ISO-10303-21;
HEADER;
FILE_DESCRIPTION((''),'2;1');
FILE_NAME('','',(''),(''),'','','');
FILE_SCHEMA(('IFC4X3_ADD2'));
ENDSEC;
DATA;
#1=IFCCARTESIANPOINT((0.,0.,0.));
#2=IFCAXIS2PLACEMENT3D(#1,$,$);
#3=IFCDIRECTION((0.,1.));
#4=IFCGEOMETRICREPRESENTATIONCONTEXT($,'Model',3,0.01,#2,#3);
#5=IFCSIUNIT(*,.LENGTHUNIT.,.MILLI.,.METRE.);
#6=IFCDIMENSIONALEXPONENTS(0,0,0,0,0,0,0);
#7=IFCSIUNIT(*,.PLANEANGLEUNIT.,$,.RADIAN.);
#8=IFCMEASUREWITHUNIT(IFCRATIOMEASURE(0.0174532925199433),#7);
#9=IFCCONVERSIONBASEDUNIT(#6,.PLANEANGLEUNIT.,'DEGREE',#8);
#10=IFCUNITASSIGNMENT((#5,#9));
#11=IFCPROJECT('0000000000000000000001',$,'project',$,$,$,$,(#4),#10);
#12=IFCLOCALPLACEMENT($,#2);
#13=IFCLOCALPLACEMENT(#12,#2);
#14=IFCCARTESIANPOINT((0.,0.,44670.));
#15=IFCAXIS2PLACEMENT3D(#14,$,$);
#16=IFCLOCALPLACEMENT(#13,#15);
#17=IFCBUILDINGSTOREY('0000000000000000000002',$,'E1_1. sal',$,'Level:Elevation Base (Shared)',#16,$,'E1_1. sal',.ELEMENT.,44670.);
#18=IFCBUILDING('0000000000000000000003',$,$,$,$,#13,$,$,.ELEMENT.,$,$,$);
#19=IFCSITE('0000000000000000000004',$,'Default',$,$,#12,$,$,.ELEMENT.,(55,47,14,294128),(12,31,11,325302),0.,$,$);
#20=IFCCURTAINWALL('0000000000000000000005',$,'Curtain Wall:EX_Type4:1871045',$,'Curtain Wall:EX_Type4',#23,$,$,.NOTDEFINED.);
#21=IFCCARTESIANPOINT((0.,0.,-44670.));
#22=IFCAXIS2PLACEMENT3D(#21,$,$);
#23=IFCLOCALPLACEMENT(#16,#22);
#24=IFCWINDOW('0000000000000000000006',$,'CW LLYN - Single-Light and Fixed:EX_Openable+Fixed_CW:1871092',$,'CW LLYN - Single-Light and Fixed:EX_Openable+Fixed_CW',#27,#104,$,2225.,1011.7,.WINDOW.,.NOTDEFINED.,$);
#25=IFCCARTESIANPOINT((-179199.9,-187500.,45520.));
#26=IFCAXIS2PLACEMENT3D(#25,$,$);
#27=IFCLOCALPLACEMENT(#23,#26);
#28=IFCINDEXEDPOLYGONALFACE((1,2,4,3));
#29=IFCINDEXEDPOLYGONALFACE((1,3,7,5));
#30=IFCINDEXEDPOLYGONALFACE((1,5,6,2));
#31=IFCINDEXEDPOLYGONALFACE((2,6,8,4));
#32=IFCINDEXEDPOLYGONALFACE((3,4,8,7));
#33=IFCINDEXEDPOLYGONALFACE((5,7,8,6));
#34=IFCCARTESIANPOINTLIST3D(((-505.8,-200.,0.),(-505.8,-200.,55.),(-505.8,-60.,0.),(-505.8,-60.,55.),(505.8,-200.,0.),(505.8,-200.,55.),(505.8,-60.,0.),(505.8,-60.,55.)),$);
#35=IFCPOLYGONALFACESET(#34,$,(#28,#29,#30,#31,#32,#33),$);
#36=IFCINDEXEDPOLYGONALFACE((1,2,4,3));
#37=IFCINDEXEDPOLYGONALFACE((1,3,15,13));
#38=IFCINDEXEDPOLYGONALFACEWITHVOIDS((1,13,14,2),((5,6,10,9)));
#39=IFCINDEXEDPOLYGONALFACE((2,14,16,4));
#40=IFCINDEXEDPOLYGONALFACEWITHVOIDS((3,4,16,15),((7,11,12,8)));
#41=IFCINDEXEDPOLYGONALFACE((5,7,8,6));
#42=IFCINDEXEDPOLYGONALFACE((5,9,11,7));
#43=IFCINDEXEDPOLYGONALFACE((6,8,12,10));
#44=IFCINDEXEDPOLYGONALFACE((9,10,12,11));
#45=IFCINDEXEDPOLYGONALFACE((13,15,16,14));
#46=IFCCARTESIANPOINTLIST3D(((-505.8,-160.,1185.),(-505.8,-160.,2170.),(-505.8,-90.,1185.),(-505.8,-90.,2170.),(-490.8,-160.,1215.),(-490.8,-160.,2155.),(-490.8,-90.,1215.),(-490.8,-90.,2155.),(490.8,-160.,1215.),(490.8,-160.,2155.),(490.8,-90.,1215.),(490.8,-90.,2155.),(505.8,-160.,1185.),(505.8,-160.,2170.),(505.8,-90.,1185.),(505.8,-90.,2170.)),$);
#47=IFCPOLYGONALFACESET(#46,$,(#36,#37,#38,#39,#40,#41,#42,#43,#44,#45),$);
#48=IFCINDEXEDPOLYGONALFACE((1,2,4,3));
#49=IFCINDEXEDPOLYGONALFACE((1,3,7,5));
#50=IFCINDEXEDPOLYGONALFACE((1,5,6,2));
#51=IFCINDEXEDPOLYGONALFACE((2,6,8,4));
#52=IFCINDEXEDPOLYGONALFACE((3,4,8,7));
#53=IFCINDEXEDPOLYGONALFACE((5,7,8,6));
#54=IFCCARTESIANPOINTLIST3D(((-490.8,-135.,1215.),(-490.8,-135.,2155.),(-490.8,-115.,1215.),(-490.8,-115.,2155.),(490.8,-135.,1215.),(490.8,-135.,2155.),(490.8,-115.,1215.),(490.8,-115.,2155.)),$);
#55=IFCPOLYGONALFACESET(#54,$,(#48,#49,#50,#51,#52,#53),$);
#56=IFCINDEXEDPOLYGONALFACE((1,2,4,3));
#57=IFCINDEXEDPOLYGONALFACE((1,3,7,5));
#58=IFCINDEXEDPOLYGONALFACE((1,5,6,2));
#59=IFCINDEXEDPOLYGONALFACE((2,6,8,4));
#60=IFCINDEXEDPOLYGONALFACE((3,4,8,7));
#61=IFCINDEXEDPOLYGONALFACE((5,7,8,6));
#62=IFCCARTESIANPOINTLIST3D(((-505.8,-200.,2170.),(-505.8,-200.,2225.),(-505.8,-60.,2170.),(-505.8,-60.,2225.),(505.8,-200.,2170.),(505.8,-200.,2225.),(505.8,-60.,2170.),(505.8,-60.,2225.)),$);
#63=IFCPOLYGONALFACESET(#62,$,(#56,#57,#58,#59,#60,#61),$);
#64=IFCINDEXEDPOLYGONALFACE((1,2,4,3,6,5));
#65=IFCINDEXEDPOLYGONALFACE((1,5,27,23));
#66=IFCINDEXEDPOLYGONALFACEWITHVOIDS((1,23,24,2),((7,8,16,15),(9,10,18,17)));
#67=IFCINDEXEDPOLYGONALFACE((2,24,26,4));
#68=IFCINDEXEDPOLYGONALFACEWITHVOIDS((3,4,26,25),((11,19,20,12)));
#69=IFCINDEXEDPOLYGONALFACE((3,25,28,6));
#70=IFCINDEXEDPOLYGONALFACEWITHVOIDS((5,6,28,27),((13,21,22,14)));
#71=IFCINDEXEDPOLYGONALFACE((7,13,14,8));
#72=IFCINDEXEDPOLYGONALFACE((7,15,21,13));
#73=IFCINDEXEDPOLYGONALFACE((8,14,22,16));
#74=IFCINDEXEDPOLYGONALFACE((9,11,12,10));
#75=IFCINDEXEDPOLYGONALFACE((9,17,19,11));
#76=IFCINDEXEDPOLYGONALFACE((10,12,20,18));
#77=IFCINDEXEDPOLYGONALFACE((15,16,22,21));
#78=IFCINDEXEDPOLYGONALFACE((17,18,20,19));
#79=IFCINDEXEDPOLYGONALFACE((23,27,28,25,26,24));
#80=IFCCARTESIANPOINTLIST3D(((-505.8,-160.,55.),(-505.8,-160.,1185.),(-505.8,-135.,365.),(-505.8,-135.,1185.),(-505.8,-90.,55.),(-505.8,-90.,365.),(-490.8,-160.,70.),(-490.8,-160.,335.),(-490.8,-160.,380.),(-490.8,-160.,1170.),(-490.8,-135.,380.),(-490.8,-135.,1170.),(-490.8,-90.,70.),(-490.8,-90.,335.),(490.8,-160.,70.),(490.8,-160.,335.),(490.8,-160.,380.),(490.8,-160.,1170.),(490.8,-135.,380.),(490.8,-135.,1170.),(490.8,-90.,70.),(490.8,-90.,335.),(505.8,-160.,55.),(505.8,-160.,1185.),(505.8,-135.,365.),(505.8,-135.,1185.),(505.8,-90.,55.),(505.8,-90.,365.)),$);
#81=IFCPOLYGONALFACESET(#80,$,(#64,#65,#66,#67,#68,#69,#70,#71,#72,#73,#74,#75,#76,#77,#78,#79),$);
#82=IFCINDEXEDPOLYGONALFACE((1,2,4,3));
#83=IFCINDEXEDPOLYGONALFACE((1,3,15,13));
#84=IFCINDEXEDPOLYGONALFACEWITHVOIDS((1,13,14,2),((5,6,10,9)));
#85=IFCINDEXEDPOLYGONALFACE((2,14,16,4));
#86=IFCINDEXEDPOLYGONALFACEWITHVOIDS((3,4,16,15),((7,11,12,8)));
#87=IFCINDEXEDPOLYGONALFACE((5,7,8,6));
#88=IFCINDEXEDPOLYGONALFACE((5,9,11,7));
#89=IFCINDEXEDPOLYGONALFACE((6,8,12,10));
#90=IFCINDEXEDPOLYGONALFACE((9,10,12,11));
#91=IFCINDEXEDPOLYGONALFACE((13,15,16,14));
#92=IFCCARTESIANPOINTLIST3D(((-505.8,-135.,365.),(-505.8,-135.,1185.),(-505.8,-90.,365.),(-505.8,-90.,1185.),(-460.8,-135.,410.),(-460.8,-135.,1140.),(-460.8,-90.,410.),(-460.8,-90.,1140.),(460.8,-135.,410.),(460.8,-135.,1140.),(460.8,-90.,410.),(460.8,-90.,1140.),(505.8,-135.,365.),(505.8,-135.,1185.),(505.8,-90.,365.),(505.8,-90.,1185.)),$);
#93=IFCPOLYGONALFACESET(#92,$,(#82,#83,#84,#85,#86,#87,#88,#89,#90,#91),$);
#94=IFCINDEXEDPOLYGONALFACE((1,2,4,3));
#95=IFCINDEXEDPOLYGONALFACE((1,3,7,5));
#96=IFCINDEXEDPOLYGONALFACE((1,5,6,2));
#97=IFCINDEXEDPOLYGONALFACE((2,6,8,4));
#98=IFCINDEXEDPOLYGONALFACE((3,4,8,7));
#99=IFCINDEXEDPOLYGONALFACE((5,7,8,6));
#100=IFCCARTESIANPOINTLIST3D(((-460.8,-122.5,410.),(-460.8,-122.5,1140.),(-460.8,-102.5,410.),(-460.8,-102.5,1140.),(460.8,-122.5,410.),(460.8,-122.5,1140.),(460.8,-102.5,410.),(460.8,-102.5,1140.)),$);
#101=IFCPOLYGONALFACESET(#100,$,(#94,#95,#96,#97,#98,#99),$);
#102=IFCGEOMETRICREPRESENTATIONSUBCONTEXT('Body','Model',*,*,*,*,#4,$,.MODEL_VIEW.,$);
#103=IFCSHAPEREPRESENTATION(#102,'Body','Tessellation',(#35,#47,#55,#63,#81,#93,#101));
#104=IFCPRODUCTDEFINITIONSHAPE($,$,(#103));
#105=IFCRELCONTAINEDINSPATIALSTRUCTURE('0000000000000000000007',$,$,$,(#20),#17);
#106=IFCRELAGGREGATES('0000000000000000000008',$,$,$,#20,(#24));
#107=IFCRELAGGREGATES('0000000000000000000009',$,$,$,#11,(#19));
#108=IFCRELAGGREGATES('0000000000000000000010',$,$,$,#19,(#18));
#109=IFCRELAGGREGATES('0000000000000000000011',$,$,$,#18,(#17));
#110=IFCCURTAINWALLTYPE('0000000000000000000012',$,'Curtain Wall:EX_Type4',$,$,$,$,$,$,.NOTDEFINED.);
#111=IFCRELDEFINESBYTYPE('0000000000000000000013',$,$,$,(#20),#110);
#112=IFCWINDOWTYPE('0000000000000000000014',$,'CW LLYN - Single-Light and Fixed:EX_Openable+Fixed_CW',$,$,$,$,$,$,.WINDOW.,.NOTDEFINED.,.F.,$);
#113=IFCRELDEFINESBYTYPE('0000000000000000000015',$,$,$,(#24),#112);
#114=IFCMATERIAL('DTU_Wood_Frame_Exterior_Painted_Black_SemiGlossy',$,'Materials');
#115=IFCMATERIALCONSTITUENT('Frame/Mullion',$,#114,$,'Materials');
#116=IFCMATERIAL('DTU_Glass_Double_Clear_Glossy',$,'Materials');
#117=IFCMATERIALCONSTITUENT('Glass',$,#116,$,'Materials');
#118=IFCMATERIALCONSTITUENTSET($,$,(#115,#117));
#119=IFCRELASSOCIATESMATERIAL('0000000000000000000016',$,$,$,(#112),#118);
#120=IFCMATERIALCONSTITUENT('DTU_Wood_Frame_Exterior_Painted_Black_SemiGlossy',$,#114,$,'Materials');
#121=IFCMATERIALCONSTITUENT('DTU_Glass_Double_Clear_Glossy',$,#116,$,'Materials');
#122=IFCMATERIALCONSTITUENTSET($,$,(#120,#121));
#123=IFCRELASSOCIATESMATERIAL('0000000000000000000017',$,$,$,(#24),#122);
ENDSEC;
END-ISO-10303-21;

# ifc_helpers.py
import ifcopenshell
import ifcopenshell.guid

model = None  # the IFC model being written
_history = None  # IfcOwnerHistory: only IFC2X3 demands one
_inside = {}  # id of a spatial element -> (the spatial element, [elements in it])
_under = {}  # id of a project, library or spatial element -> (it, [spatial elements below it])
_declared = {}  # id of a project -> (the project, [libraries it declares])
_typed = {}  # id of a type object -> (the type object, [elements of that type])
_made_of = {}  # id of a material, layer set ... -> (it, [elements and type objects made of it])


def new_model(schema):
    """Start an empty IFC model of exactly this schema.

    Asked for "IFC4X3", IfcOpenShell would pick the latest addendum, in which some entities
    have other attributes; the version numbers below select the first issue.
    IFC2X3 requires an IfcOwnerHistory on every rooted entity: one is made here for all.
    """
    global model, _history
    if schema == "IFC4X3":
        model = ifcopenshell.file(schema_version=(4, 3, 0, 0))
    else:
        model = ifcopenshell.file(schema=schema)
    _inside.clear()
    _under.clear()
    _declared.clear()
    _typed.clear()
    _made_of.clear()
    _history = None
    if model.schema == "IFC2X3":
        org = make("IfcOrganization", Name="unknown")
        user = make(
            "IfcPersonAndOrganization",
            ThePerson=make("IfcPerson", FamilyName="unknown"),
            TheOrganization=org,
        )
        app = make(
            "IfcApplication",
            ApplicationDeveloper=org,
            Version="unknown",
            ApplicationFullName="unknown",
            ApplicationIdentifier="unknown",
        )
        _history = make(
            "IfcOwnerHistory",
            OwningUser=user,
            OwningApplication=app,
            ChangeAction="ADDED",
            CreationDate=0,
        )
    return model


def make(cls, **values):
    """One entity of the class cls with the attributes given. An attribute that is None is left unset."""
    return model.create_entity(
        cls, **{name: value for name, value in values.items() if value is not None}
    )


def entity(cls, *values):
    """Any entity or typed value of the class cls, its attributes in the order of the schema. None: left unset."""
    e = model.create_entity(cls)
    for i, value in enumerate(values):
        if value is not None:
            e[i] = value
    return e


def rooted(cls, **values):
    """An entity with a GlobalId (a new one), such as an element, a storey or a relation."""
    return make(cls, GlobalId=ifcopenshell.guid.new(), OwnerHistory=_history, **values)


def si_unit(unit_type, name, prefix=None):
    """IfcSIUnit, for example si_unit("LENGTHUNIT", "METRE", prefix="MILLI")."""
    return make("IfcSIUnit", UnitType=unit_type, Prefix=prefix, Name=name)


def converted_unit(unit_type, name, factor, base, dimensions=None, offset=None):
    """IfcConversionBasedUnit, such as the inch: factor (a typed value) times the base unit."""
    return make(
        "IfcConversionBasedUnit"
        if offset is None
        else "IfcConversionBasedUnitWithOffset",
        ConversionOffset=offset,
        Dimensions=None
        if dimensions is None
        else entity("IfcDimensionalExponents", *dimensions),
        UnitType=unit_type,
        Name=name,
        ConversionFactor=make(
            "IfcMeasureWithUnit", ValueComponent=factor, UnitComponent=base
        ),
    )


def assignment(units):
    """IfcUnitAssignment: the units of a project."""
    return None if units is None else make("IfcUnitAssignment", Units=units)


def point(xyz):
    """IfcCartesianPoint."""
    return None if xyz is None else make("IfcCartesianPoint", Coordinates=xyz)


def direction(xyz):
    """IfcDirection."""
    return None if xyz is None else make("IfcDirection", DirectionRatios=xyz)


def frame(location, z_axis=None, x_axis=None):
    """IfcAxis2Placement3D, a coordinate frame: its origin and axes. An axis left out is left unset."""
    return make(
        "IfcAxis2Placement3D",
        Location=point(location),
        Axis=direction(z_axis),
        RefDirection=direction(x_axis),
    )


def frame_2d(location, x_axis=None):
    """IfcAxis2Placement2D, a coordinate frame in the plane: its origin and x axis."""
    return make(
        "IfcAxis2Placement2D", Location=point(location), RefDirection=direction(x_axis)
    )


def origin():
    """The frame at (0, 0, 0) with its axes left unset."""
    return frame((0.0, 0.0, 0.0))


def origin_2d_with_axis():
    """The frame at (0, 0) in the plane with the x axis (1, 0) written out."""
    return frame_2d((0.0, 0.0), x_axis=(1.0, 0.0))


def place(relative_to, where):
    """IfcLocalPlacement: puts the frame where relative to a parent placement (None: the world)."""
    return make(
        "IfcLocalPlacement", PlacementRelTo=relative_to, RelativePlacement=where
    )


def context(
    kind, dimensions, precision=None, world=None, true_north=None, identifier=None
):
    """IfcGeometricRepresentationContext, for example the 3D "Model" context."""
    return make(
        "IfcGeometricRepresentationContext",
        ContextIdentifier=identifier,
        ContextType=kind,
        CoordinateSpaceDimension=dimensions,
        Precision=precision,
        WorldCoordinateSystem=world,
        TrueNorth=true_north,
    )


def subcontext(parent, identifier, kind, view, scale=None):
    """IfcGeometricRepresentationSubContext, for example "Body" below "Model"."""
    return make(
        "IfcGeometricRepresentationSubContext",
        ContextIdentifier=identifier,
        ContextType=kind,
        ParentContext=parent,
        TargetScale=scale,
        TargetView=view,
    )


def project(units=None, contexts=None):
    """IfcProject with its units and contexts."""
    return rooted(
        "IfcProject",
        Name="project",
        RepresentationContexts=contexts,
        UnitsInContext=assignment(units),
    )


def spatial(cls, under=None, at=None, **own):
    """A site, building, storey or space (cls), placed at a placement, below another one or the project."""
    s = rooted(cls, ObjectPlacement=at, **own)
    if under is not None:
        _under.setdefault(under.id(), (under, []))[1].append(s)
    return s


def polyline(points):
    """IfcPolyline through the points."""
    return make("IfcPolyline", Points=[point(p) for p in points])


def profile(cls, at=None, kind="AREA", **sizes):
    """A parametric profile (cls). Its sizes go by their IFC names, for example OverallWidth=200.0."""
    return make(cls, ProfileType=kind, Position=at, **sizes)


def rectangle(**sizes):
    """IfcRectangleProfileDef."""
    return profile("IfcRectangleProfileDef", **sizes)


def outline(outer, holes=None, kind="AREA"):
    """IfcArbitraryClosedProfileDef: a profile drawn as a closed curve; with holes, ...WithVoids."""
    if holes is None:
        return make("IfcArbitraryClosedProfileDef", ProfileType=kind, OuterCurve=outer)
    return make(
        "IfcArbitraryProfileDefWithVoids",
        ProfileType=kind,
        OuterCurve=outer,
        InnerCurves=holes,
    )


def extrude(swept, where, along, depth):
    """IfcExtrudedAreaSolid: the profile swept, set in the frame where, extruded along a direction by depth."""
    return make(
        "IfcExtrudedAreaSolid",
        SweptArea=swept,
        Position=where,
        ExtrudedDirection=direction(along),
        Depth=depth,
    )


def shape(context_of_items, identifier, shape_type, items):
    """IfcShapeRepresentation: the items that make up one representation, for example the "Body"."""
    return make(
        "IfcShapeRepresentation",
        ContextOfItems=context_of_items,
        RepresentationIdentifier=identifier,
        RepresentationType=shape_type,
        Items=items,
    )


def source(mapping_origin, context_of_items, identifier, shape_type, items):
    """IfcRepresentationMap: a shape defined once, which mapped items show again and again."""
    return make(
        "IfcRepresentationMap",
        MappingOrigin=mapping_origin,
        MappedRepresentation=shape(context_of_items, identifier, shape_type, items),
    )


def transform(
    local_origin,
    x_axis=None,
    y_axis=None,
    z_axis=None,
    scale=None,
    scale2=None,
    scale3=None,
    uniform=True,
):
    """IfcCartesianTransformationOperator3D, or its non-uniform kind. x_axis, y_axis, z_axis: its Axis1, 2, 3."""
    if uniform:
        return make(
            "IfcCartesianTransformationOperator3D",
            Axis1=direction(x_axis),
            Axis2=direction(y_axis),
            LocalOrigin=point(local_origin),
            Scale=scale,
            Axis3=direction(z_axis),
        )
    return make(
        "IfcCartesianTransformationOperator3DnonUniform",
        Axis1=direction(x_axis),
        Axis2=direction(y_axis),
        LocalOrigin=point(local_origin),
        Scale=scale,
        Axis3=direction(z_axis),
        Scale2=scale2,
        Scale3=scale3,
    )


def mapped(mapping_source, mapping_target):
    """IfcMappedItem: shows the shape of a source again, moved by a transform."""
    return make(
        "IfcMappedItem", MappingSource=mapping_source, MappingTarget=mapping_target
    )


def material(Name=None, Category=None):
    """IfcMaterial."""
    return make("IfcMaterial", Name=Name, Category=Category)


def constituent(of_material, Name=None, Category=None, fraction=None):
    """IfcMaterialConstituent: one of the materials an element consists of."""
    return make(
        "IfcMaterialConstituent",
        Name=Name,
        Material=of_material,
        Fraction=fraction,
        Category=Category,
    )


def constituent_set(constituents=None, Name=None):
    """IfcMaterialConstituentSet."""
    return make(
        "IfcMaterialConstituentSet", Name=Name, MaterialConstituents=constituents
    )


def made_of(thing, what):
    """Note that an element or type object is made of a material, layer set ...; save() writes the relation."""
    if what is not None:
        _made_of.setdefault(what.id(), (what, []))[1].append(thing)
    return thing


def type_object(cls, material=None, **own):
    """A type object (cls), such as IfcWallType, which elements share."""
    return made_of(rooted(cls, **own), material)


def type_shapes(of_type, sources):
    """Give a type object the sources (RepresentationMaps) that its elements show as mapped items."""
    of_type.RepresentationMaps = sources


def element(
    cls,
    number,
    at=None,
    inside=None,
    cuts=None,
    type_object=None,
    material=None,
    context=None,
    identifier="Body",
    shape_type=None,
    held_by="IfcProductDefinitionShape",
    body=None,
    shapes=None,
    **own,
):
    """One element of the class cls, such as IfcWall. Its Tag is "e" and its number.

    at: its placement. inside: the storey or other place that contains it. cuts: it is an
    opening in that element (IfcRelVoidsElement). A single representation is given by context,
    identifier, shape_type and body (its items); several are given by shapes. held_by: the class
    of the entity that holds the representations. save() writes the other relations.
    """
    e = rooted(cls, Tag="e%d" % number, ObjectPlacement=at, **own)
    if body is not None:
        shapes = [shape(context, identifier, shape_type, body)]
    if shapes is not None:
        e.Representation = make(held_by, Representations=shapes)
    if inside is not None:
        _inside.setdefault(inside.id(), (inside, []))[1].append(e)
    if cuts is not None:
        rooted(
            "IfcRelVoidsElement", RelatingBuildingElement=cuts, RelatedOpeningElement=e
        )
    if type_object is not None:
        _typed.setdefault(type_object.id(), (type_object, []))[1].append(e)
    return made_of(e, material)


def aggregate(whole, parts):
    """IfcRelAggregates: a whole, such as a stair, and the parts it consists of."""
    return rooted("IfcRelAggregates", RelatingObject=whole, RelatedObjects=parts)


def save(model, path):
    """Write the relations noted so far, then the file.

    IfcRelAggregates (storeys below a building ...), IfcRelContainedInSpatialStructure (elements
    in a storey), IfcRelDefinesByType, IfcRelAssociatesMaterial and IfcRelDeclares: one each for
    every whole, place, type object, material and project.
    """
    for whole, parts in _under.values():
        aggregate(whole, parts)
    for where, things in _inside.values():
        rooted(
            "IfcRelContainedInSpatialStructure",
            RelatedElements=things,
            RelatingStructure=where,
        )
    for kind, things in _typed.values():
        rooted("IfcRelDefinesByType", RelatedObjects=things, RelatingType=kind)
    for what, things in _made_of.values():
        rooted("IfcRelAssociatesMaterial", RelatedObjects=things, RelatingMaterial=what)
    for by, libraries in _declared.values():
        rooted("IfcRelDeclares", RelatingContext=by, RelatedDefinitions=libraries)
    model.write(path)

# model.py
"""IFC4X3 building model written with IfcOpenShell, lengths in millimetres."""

from ifc_helpers import new_model, entity, si_unit, converted_unit, direction, frame, frame_2d, origin, origin_2d_with_axis, place, context, subcontext, project, spatial, polyline, rectangle, outline, extrude, source, transform, mapped, material, constituent, constituent_set, type_object, type_shapes, element, aggregate, save


model = new_model("IFC4X3")

# Units and contexts
model_context = context("Model", 3, precision=0.01, world=origin(), true_north=direction((0.0, 1.0)))
body_context = subcontext(model_context, "Body", "Model", "MODEL_VIEW")
ifc_project = project(units=[si_unit("LENGTHUNIT", "METRE", prefix="MILLI"), converted_unit("PLANEANGLEUNIT", "DEGREE", entity("IfcRatioMeasure", 0.0174532925199433), si_unit("PLANEANGLEUNIT", "RADIAN"), dimensions=[0, 0, 0, 0, 0, 0, 0])], contexts=[model_context])

# Site, building, storey
site_placement = place(None, origin())
site = spatial("IfcSite", under=ifc_project, at=site_placement, Name="Default", CompositionType="ELEMENT", RefLatitude=(55, 47, 14, 294128), RefLongitude=(12, 31, 11, 325302), RefElevation=0.0)
building_placement = place(site_placement, origin())
building = spatial("IfcBuilding", under=site, at=building_placement, CompositionType="ELEMENT")
storey_placement = place(building_placement, frame((0.0, 0.0, 44670.0)))
storey = spatial("IfcBuildingStorey", under=building, at=storey_placement, Name="E1_1. sal", ObjectType="Level:Elevation Base (Shared)", LongName="E1_1. sal", CompositionType="ELEMENT", Elevation=44670.0)

# Curtain wall
curtain_wall_type_1 = type_object("IfcCurtainWallType", Name="Curtain Wall:EX_Type4", PredefinedType="NOTDEFINED")
curtain_wall_1_placement = place(storey_placement, frame((0.0, 0.0, -44670.0)))
curtain_wall_1 = element("IfcCurtainWall", 1, at=curtain_wall_1_placement, inside=storey, type_object=curtain_wall_type_1, Name="Curtain Wall:EX_Type4:1871045", ObjectType="Curtain Wall:EX_Type4", PredefinedType="NOTDEFINED")

# Shared definitions
ifc_material_1 = material(Name="DTU_Wood_Frame_Exterior_Painted_Black_SemiGlossy", Category="Materials")
ifc_material_2 = material(Name="DTU_Glass_Double_Clear_Glossy", Category="Materials")

# Window, openings
ifc_constituent_1 = constituent(ifc_material_1, Name="DTU_Wood_Frame_Exterior_Painted_Black_SemiGlossy", Category="Materials")
ifc_constituent_2 = constituent(ifc_material_2, Name="DTU_Glass_Double_Clear_Glossy", Category="Materials")
ifc_constituent_set_1 = constituent_set(constituents=[ifc_constituent_1, ifc_constituent_2])
ifc_constituent_3 = constituent(ifc_material_1, Name="Frame/Mullion", Category="Materials")
ifc_constituent_4 = constituent(ifc_material_2, Name="Glass", Category="Materials")
ifc_constituent_set_2 = constituent_set(constituents=[ifc_constituent_3, ifc_constituent_4])
window_type_1 = type_object("IfcWindowType", Name="CW LLYN - Single-Light and Fixed:EX_Openable+Fixed_CW", ParameterTakesPrecedence=False, PartitioningType="NOTDEFINED", PredefinedType="WINDOW", material=ifc_constituent_set_2)
shared_shape_1 = source(origin(), body_context, "Body", "SweptSolid", [
    extrude(rectangle(XDim=140.0, YDim=1011.7, at=origin_2d_with_axis()), frame((0.0, -130.0, 0.0), z_axis=(0.0, 0.0, 1.0), x_axis=(0.0, -1.0, 0.0)), (0.0, 0.0, 1.0), 55.0),
    extrude(outline(polyline([(-492.5, -505.8), (492.5, -505.8), (492.5, 505.8), (-492.5, 505.8), (-492.5, -505.8)]), holes=[polyline([(477.5, -490.8), (-462.5, -490.8), (-462.5, 490.8), (477.5, 490.8), (477.5, -490.8)])]), frame((0.0, -90.0, 1677.5), z_axis=(0.0, -1.0, 0.0), x_axis=(0.0, 0.0, 1.0)), (0.0, 0.0, 1.0), 70.0),
    extrude(rectangle(XDim=981.7, YDim=20.0, at=frame_2d((0.0, 0.0), x_axis=(1.0, 0.0))), frame((0.0, -125.0, 1215.0), z_axis=(0.0, 0.0, 1.0), x_axis=(-1.0, 0.0, 0.0)), (0.0, 0.0, 1.0), 940.0),
    extrude(rectangle(XDim=981.7, YDim=20.0, at=frame_2d((0.0, 0.0), x_axis=(1.0, 0.0))), frame((0.0, -125.0, 70.0), z_axis=(0.0, 0.0, 1.0), x_axis=(-1.0, 0.0, 0.0)), (0.0, 0.0, 1.0), 265.0),
    extrude(rectangle(XDim=140.0, YDim=1011.7, at=frame_2d((0.0, 0.0), x_axis=(1.0, 0.0))), frame((0.0, -130.0, 2170.0), z_axis=(0.0, 0.0, 1.0), x_axis=(0.0, -1.0, 0.0)), (0.0, 0.0, 1.0), 55.0),
    extrude(outline(polyline([(-38.3, -480.0), (31.7, -480.0), (31.7, 650.0), (6.7, 650.0), (6.7, -170.0), (-38.3, -170.0), (-38.3, -480.0)])), frame((505.8, -128.3, 535.0), z_axis=(-1.0, 0.0, 0.0), x_axis=(0.0, -1.0, 0.0)), (0.0, 0.0, 1.0), 1011.7),
    extrude(outline(polyline([(-410.0, -505.8), (410.0, -505.8), (410.0, 505.8), (-410.0, 505.8), (-410.0, -505.8)]), holes=[polyline([(-365.0, 460.8), (365.0, 460.8), (365.0, -460.8), (-365.0, -460.8), (-365.0, 460.8)])]), frame((0.0, -90.0, 775.0), z_axis=(0.0, -1.0, 0.0), x_axis=(0.0, 0.0, 1.0)), (0.0, 0.0, 1.0), 45.0),
    extrude(rectangle(XDim=921.7, YDim=20.0, at=frame_2d((0.0, 0.0), x_axis=(1.0, 0.0))), frame((0.0, -112.5, 410.0), z_axis=(0.0, 0.0, 1.0), x_axis=(-1.0, 0.0, 0.0)), (0.0, 0.0, 1.0), 730.0),
])
type_shapes(window_type_1, [shared_shape_1])
window_1_placement = place(curtain_wall_1_placement, frame((-179199.9, -187500.0, 45520.0)))
window_1 = element("IfcWindow", 2, at=window_1_placement, type_object=window_type_1, material=ifc_constituent_set_1, Name="CW LLYN - Single-Light and Fixed:EX_Openable+Fixed_CW:1871092", ObjectType="CW LLYN - Single-Light and Fixed:EX_Openable+Fixed_CW", OverallHeight=2225.0, OverallWidth=1011.7, PartitioningType="NOTDEFINED", PredefinedType="WINDOW", context=body_context, shape_type="MappedRepresentation", body=[
    mapped(shared_shape_1, transform((0.0, 0.0, 0.0), scale=1.0)),
])
opening_1_placement = place(curtain_wall_1_placement, frame((-179199.9, -187500.0, 90190.0), z_axis=(0.0, 0.0, 1.0), x_axis=(-1.0, 0.0, 0.0)))
opening_1 = element("IfcOpeningElement", 3, at=opening_1_placement, cuts=window_1, PredefinedType="OPENING", context=body_context, shape_type="SweptSolid", body=[
    extrude(rectangle(XDim=265.0, YDim=981.7, at=frame_2d((0.0, 0.0), x_axis=(1.0, 0.0))), frame((0.0, 160.0, -44467.5), z_axis=(0.0, -1.0, 0.0), x_axis=(0.0, 0.0, 1.0)), (0.0, 0.0, 1.0), 70.0),
])
opening_2_placement = place(curtain_wall_1_placement, frame((-179199.9, -187500.0, 90190.0), z_axis=(0.0, 0.0, 1.0), x_axis=(-1.0, 0.0, 0.0)))
opening_2 = element("IfcOpeningElement", 4, at=opening_2_placement, cuts=window_1, PredefinedType="OPENING", context=body_context, shape_type="SweptSolid", body=[
    extrude(rectangle(XDim=790.0, YDim=981.7, at=frame_2d((0.0, 0.0), x_axis=(1.0, 0.0))), frame((0.0, 135.0, -43895.0), z_axis=(0.0, 1.0, 0.0), x_axis=(0.0, 0.0, 1.0)), (0.0, 0.0, 1.0), 25.0),
])

aggregate(curtain_wall_1, [window_1, opening_1, opening_2])

save(model, "model.ifc")
